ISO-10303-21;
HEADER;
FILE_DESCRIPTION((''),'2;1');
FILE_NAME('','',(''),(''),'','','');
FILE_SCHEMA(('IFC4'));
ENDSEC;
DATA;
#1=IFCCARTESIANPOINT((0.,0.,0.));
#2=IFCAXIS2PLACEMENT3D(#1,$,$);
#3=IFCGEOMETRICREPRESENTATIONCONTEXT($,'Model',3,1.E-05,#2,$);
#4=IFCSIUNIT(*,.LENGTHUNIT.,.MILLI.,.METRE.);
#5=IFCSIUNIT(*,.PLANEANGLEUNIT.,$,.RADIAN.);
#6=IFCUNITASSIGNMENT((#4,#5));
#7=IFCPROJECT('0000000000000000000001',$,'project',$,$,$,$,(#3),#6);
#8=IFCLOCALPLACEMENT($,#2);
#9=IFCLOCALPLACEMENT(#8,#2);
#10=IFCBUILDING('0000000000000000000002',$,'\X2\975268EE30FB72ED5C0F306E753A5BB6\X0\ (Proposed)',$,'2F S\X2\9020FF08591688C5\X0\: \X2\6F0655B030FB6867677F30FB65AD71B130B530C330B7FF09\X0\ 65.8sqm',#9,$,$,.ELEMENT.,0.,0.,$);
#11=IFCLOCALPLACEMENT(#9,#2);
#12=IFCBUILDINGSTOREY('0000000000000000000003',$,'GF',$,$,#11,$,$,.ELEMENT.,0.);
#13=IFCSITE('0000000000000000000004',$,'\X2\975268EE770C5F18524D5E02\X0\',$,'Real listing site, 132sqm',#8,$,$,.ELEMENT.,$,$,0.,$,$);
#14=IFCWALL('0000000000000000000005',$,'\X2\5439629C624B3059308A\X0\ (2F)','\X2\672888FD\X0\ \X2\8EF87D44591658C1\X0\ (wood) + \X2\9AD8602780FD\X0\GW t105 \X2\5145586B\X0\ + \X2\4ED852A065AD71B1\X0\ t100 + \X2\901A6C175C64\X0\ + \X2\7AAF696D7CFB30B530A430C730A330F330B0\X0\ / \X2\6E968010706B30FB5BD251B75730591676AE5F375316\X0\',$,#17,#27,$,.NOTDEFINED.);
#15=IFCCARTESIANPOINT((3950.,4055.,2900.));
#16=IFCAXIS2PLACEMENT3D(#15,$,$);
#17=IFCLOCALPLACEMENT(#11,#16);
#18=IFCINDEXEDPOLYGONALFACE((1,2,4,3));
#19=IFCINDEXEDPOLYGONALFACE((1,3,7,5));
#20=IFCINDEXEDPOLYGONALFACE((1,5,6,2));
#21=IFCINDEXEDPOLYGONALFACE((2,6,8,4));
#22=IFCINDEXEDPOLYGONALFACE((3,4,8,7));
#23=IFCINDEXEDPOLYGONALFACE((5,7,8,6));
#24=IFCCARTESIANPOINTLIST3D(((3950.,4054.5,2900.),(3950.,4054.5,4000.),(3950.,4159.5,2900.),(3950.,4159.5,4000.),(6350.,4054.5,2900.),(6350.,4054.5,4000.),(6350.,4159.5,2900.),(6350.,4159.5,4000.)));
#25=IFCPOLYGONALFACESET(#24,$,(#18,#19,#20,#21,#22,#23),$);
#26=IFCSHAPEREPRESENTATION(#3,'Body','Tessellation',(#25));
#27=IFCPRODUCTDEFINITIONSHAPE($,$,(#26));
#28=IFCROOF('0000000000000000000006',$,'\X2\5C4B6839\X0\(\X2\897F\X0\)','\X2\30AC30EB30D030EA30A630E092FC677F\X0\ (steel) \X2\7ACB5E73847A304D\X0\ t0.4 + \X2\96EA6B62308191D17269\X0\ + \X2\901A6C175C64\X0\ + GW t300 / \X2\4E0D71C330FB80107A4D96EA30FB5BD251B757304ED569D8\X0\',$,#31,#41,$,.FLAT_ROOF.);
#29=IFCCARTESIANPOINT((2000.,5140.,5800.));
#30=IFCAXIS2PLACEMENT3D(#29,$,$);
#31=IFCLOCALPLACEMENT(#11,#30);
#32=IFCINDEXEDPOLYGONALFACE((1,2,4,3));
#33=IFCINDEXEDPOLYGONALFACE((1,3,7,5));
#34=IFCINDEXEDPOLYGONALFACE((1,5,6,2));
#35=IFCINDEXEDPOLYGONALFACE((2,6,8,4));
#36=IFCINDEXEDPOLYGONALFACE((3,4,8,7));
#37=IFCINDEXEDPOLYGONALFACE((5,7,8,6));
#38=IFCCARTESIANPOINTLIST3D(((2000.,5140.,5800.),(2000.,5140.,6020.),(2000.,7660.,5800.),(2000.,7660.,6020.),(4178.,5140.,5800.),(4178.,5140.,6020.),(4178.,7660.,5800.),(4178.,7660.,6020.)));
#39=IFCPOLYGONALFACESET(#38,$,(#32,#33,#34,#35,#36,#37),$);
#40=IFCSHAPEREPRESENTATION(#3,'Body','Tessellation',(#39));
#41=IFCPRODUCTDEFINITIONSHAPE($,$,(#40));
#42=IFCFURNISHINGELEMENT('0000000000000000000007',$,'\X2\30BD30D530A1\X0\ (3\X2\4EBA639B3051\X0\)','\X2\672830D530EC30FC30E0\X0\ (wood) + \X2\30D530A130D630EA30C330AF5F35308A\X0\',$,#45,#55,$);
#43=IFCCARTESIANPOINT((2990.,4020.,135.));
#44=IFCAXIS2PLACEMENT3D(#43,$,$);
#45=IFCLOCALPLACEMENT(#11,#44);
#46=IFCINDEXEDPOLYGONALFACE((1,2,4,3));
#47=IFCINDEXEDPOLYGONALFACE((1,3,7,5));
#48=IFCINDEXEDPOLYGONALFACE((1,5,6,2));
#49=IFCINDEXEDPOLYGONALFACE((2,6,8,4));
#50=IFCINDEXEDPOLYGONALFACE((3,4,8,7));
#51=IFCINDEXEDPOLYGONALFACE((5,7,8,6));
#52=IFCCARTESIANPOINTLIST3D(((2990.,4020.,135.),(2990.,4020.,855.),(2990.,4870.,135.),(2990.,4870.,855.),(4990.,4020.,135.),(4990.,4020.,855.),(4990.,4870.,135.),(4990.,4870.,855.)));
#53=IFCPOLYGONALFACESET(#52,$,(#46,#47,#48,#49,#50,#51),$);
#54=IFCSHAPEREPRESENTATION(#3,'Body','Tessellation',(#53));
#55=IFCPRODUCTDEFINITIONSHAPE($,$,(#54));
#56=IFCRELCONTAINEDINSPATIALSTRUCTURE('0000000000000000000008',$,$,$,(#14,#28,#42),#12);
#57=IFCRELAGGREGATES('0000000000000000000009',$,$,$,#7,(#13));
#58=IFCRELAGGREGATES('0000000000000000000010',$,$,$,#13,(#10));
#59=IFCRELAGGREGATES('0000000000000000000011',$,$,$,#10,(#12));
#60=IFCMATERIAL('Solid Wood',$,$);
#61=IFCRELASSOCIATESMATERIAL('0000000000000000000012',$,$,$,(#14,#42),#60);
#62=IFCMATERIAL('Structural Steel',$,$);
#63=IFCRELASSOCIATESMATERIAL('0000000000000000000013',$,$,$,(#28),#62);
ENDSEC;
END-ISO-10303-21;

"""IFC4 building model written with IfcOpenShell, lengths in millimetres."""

from ifc_helpers import new_model, si_unit, frame, frame_2d, origin, place, context, project, spatial, rectangle, extrude, material, element, save


model = new_model("IFC4")

# Units and contexts
model_context = context("Model", 3, precision=1e-05, world=origin())
ifc_project = project(units=[si_unit("LENGTHUNIT", "METRE", prefix="MILLI"), si_unit("PLANEANGLEUNIT", "RADIAN")], contexts=[model_context])

# Site, building, storey
site_placement = place(None, origin())
site = spatial("IfcSite", under=ifc_project, at=site_placement, Name="青森県弘前市", ObjectType="Real listing site, 132sqm", CompositionType="ELEMENT", RefElevation=0.0)
building_placement = place(site_placement, origin())
building = spatial("IfcBuilding", under=site, at=building_placement, Name="青森・狭小の町家 (Proposed)", ObjectType="2F S造（外装: 漆喰・桧板・断熱サッシ） 65.8sqm", CompositionType="ELEMENT", ElevationOfRefHeight=0.0, ElevationOfTerrain=0.0)
storey_placement = place(building_placement, origin())
storey = spatial("IfcBuildingStorey", under=building, at=storey_placement, Name="GF", CompositionType="ELEMENT", Elevation=0.0)

# Shared definitions
ifc_material_1 = material(Name="Solid Wood")

# Wall
wall_1_placement = place(storey_placement, frame((3950.0, 4055.0, 2900.0)))
element("IfcWall", 1, at=wall_1_placement, inside=storey, material=ifc_material_1, Name="吹抜手すり (2F)", Description="木製 軸組外壁 (wood) + 高性能GW t105 充填 + 付加断熱 t100 + 通気層 + 窯業系サイディング / 準耐火・寒冷地外皮強化", PredefinedType="NOTDEFINED", context=model_context, shape_type="SweptSolid", body=[
    extrude(rectangle(XDim=2400.0, YDim=105.0, at=frame_2d((1200.0, 52.0))), frame((3950.0, 4055.0, 2900.0)), (0.0, 0.0, 1.0), 1100.0),
])

# Roof
ifc_material_2 = material(Name="Structural Steel")
for number, where, name in (
    (2, (2000.0, 5140.0, 5800.0), "屋根(西)"),
):
    element("IfcRoof", number, at=place(storey_placement, frame(where)), inside=storey, material=ifc_material_2, Name=name, Description="ガルバリウム鋼板 (steel) 立平葺き t0.4 + 雪止め金物 + 通気層 + GW t300 / 不燃・耐積雪・寒冷地仕様", PredefinedType="FLAT_ROOF", context=model_context, shape_type="SweptSolid", body=[
        extrude(rectangle(XDim=2178.0, YDim=2520.0, at=frame_2d((1089.0, 1260.0))), frame((2000.0, 5140.0, 5800.0)), (0.0, 0.0, 1.0), 220.0),
    ])

# Furnishing element
furnishing_placement = place(storey_placement, frame((2990.0, 4020.0, 135.0)))
element("IfcFurnishingElement", 3, at=furnishing_placement, inside=storey, material=ifc_material_1, Name="ソファ (3人掛け)", Description="木フレーム (wood) + ファブリック張り", context=model_context, shape_type="SweptSolid", body=[
    extrude(rectangle(XDim=2000.0, YDim=850.0, at=frame_2d((1000.0, 425.0))), frame((2990.0, 4020.0, 135.0)), (0.0, 0.0, 1.0), 720.0),
])

save(model, "model.ifc")
